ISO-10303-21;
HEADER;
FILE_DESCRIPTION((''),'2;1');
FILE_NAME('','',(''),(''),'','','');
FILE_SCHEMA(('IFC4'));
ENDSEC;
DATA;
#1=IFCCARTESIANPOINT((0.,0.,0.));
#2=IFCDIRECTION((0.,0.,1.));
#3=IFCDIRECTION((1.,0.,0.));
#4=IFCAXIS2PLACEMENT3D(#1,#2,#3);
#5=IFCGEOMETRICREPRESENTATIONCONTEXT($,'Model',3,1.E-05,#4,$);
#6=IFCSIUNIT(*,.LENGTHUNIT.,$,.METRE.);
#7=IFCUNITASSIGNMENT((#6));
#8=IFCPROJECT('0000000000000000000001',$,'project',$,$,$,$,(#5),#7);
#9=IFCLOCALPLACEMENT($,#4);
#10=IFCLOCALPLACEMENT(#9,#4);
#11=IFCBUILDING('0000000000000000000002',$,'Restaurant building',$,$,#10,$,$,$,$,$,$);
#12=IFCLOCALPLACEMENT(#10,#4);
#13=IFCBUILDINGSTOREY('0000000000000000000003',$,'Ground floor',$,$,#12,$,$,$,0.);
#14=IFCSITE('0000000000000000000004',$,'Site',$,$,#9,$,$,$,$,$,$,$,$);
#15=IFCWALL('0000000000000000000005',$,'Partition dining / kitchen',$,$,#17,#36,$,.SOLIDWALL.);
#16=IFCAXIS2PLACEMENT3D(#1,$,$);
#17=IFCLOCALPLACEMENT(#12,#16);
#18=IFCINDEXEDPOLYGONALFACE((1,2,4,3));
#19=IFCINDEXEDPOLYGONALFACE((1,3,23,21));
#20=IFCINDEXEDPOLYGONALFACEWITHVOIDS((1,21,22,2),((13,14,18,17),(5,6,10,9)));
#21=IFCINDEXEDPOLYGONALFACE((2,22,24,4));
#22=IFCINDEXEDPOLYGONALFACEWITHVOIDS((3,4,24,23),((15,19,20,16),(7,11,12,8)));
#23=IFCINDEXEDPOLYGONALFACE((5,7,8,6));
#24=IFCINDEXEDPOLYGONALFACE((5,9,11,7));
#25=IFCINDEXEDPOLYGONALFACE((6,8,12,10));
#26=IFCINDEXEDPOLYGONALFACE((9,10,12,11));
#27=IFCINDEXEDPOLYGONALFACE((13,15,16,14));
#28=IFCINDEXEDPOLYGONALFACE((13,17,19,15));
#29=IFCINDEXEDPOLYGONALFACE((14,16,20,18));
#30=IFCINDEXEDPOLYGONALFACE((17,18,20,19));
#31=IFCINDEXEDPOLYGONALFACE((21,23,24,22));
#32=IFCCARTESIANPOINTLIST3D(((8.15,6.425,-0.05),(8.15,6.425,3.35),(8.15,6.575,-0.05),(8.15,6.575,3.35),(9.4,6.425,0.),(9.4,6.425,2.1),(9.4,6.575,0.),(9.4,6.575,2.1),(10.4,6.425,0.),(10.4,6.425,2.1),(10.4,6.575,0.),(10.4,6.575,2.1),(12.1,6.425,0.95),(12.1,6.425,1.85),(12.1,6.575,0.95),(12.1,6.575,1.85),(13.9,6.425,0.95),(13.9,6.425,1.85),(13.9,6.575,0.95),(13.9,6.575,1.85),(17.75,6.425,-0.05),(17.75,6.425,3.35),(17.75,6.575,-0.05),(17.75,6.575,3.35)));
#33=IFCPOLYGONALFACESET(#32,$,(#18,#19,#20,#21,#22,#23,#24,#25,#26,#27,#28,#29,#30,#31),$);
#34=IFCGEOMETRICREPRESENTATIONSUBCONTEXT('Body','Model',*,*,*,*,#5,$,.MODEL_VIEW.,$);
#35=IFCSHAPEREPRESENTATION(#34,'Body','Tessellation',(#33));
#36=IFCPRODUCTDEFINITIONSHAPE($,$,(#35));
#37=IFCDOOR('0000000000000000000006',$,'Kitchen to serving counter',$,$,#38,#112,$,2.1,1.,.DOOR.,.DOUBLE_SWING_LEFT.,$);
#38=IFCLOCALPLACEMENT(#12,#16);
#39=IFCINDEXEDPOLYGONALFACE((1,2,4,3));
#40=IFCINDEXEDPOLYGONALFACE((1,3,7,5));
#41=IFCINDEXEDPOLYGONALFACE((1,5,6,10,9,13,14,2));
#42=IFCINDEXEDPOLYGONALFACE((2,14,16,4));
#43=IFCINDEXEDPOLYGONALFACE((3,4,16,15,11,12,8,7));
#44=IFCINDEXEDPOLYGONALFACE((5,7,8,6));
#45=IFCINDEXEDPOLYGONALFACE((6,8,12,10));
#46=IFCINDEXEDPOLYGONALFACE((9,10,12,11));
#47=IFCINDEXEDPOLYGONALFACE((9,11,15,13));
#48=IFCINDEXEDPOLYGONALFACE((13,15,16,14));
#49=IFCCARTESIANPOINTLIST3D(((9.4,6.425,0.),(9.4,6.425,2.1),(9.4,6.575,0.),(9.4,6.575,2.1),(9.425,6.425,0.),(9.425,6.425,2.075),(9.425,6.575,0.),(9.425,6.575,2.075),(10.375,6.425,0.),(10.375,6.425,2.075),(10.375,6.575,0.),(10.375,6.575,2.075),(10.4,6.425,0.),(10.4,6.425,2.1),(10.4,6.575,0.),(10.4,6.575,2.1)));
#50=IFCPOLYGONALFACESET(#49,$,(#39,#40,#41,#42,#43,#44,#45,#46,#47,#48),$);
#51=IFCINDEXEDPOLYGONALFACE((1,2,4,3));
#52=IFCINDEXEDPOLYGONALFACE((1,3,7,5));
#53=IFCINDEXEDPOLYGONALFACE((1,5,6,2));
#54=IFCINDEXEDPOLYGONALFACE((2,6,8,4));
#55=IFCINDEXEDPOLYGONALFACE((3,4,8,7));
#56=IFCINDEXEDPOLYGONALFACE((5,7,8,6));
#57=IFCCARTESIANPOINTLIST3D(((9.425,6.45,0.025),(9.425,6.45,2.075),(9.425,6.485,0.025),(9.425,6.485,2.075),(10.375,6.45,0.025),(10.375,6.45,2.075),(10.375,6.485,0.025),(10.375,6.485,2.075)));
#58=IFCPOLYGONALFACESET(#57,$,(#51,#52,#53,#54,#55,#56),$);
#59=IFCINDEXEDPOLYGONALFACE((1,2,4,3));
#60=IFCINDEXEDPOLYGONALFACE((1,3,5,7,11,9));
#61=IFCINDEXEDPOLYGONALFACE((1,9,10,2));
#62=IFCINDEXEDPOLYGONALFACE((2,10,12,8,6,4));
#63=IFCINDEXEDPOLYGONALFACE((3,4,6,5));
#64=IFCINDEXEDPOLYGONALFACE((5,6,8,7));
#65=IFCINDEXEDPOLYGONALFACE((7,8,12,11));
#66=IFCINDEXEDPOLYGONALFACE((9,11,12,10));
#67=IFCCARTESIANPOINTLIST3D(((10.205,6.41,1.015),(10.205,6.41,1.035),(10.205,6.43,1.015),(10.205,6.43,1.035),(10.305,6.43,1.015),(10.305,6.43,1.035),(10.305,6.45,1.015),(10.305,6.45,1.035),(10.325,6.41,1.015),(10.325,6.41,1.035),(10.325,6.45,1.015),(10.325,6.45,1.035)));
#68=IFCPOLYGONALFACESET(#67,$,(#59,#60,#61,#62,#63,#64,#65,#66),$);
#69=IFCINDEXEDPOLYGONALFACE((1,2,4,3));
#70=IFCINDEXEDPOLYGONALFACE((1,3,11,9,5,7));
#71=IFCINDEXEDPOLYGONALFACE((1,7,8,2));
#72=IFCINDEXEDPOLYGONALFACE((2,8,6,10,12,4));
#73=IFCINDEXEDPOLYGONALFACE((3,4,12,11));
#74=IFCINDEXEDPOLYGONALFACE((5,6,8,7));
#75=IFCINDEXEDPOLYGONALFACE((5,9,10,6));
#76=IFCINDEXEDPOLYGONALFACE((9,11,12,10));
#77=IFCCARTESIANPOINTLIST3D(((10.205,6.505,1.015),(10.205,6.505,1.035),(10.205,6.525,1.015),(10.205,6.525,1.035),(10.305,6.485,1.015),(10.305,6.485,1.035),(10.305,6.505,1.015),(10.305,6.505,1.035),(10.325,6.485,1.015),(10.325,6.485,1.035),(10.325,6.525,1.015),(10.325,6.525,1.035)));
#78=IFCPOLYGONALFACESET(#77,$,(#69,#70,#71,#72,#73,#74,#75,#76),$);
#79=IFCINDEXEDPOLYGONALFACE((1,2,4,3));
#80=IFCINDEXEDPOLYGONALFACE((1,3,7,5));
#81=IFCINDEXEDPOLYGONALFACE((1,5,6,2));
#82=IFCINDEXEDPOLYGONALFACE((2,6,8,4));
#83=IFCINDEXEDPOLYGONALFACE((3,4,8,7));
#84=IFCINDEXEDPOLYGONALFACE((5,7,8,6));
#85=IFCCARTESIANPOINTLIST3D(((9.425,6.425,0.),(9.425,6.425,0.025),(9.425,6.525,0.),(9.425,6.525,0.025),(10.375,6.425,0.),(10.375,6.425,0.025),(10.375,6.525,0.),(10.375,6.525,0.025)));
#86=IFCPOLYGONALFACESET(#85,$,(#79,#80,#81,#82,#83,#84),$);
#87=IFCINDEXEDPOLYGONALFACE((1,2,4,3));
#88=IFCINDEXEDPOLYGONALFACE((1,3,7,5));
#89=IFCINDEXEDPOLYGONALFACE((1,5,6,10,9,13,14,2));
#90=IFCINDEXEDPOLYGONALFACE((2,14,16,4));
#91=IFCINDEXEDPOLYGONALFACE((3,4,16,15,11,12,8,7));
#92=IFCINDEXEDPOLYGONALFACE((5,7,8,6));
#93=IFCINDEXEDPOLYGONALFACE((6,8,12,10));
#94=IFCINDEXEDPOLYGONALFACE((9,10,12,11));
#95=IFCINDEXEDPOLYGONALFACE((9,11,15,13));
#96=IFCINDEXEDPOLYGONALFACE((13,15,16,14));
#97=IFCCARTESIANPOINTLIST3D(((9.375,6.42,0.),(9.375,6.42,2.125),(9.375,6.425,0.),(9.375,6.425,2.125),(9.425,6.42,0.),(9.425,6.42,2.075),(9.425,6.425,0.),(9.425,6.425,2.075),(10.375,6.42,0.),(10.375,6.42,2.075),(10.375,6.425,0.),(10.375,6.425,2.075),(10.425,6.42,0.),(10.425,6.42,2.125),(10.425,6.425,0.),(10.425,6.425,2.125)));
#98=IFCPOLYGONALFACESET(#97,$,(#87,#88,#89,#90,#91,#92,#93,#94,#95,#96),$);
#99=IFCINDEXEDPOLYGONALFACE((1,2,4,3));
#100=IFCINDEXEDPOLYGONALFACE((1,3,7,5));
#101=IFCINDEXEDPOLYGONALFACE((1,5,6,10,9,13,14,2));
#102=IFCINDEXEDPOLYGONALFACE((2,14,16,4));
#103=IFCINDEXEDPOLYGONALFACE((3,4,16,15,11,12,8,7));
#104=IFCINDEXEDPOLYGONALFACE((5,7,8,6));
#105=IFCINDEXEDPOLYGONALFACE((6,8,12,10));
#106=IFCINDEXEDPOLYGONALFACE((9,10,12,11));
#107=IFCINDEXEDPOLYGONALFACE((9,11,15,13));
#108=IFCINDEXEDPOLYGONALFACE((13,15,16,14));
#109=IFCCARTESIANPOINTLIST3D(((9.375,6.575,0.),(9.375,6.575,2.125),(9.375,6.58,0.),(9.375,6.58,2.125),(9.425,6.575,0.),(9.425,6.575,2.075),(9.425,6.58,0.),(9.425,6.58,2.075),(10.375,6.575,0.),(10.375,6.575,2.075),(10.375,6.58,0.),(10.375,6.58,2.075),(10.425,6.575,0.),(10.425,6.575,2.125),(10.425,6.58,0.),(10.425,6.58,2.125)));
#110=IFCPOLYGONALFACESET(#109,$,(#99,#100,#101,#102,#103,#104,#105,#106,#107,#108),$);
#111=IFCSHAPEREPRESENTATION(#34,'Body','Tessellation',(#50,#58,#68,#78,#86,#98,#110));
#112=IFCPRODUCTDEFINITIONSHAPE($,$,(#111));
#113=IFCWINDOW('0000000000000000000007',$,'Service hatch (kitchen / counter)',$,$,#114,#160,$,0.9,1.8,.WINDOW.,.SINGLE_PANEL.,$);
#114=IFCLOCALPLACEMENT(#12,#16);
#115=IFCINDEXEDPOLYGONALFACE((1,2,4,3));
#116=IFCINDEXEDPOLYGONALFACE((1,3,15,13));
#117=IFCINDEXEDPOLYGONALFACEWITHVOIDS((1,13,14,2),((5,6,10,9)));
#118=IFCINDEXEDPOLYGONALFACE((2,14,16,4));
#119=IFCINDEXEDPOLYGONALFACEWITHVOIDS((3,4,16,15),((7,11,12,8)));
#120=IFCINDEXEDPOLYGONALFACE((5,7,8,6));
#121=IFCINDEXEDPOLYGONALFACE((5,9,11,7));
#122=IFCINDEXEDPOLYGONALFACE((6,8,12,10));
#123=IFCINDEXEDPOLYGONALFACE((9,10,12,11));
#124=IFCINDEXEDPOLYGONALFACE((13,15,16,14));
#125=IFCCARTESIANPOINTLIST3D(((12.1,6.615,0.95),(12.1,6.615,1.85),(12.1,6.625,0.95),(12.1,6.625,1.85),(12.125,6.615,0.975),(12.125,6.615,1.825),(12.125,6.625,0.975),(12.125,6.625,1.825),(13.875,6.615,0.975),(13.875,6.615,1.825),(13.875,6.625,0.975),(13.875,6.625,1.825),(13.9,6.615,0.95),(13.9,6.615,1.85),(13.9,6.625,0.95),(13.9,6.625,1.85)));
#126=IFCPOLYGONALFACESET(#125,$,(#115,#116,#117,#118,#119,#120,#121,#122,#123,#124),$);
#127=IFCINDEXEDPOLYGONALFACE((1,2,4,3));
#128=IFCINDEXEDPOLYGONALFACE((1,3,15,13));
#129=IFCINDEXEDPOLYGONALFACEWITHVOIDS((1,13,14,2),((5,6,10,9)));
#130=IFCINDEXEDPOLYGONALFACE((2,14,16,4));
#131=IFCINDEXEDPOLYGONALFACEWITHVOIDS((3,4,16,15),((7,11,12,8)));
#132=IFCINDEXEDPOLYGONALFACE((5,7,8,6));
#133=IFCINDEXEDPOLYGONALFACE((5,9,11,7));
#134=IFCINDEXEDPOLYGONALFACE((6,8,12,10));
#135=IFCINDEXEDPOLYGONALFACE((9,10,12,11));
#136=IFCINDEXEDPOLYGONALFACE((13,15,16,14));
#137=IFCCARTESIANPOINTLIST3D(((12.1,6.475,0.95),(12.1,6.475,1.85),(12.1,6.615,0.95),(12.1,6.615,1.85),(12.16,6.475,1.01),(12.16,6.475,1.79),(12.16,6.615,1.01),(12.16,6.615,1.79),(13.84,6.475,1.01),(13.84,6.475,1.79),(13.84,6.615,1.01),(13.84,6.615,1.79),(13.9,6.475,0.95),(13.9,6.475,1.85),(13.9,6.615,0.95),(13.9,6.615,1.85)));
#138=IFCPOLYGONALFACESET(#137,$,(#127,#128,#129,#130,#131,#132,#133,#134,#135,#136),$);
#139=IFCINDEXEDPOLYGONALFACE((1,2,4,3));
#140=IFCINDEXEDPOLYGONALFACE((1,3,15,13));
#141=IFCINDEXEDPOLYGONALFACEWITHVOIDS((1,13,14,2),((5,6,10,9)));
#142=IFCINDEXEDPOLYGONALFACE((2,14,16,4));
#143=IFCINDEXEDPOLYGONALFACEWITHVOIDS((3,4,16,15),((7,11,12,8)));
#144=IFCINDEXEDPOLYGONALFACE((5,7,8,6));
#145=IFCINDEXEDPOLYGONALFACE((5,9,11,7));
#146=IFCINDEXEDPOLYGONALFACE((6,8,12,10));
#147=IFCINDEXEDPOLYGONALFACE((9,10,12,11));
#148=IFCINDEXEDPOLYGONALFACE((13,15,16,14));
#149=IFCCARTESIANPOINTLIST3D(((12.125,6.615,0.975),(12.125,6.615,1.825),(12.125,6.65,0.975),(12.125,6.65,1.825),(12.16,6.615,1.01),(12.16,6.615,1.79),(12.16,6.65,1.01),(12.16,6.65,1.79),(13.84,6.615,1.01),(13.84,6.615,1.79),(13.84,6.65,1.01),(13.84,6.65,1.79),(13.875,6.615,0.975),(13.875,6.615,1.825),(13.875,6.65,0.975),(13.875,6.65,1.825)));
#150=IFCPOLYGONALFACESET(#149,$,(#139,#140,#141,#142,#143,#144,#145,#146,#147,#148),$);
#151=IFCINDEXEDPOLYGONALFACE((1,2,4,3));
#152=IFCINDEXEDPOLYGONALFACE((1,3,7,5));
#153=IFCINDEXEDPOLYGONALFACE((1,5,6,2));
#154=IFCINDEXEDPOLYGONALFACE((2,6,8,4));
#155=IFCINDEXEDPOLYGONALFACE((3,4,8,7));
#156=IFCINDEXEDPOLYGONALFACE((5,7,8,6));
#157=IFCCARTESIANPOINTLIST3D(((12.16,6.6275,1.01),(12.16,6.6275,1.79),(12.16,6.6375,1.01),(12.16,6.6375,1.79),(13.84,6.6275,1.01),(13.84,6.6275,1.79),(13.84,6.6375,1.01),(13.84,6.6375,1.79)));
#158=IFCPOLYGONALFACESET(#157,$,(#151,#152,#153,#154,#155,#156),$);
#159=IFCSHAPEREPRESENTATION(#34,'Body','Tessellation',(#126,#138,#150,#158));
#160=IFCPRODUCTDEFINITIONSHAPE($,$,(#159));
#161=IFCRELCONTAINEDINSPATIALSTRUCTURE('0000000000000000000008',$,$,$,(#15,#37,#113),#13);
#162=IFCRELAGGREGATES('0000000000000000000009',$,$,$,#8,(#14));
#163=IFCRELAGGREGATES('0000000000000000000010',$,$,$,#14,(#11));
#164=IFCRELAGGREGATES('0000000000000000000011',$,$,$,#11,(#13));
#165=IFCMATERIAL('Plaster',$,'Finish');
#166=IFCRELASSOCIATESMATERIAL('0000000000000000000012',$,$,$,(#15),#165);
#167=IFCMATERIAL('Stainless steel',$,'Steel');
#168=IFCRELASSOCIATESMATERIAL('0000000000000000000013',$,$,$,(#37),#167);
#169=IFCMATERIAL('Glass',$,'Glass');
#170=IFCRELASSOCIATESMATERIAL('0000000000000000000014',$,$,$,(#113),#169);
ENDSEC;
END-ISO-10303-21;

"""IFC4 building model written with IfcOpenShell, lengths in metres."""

from ifc_helpers import new_model, si_unit, frame, origin_with_axes, origin_2d, place, context, subcontext, project, spatial, line, indexed_curve, rectangle, outline, extrude, material, element, fill, save


model = new_model("IFC4")

# Units and contexts
model_context = context("Model", 3, precision=1e-05, world=origin_with_axes())
body_context = subcontext(model_context, "Body", "Model", "MODEL_VIEW")
ifc_project = project(units=[si_unit("LENGTHUNIT", "METRE")], contexts=[model_context])

# Site, building, storey
site_placement = place(None, origin_with_axes())
site = spatial("IfcSite", under=ifc_project, at=site_placement, Name="Site")
building_placement = place(site_placement, origin_with_axes())
building = spatial("IfcBuilding", under=site, at=building_placement, Name="Restaurant building")
storey_placement = place(building_placement, origin_with_axes())
storey = spatial("IfcBuildingStorey", under=building, at=storey_placement, Name="Ground floor", Elevation=0.0)

# Wall, openings, door, window
ifc_material_1 = material(Name="Plaster", Category="Finish")
wall_1_placement = place(storey_placement, frame((8.15, 6.5, 0.0)))
wall_1 = element("IfcWall", 1, at=wall_1_placement, inside=storey, material=ifc_material_1, Name="Partition dining / kitchen", PredefinedType="SOLIDWALL", context=body_context, shape_type="SweptSolid", body=[
    extrude(rectangle(XDim=9.6, YDim=0.15, at=origin_2d()), frame((4.8, 0.0, -0.05)), (0.0, 0.0, 1.0), 3.4),
])
opening_1_placement = place(wall_1_placement, frame((1.25, -0.075, 0.0), z_axis=(0.0, 0.0, 1.0), x_axis=(1.0, 0.0, 0.0)))
opening_1 = element("IfcOpeningElement", 2, at=opening_1_placement, cuts=wall_1, PredefinedType="OPENING", context=body_context, shape_type="SweptSolid", body=[
    extrude(rectangle(XDim=1.0, YDim=0.25, at=origin_2d()), frame((0.5, 0.075, 0.0)), (0.0, 0.0, 1.0), 2.1),
])
opening_2_placement = place(wall_1_placement, frame((3.95, -0.075, 0.95), z_axis=(0.0, 0.0, 1.0), x_axis=(1.0, 0.0, 0.0)))
opening_2 = element("IfcOpeningElement", 3, at=opening_2_placement, cuts=wall_1, PredefinedType="OPENING", context=body_context, shape_type="SweptSolid", body=[
    extrude(rectangle(XDim=1.8, YDim=0.25, at=origin_2d()), frame((0.9, 0.075, 0.0)), (0.0, 0.0, 1.0), 0.9),
])
ifc_material_2 = material(Name="Stainless steel", Category="Steel")
door_1_placement = place(storey_placement, frame((9.4, 6.425, 0.0)))
door_1 = element("IfcDoor", 4, at=door_1_placement, inside=storey, material=ifc_material_2, Name="Kitchen to serving counter", OperationType="DOUBLE_SWING_LEFT", OverallHeight=2.1, OverallWidth=1.0, PredefinedType="DOOR", context=body_context, shape_type="SweptSolid", body=[
    extrude(outline(indexed_curve([(0.0, 0.0), (0.0, 2.1), (1.0, 2.1), (1.0, 0.0), (0.975, 0.0), (0.975, 2.075), (0.025, 2.075), (0.025, 0.0)], segments=[line(1, 2, 3, 4, 5, 6, 7, 8, 1)])), frame((0.0, 0.0, 0.0), z_axis=(0.0, -1.0, 0.0), x_axis=(1.0, 0.0, 0.0)), (0.0, 0.0, -1.0), 0.15),
    extrude(outline(indexed_curve([(0.0, 0.0), (0.95, 0.0), (0.95, 0.035), (0.0, 0.035)], segments=[line(1, 2, 3, 4, 1)])), frame((0.025, 0.025, 0.025), z_axis=(0.0, 0.0, 1.0), x_axis=(1.0, 0.0, 0.0)), (0.0, 0.0, 1.0), 2.05),
    extrude(outline(indexed_curve([(0.0, 0.0), (0.0, -0.04), (-0.12, -0.04), (-0.12, -0.02), (-0.02, -0.02), (-0.02, 0.0)], segments=[line(1, 2, 3, 4, 5, 6, 1)])), frame((0.925, 0.025, 1.015), z_axis=(0.0, 0.0, 1.0), x_axis=(1.0, 0.0, 0.0)), (0.0, 0.0, 1.0), 0.02),
    extrude(outline(indexed_curve([(0.0, 0.0), (0.0, 0.04), (-0.12, 0.04), (-0.12, 0.02), (-0.02, 0.02), (-0.02, 0.0)], segments=[line(1, 2, 3, 4, 5, 6, 1)])), frame((0.925, 0.06, 1.015), z_axis=(0.0, 0.0, 1.0), x_axis=(1.0, 0.0, 0.0)), (0.0, 0.0, 1.0), 0.02),
    extrude(outline(indexed_curve([(0.0, 0.0), (0.95, 0.0), (0.95, 0.1), (0.0, 0.1)], segments=[line(1, 2, 3, 4, 1)])), frame((0.025, 0.0, 0.0), z_axis=(0.0, 0.0, 1.0), x_axis=(1.0, 0.0, 0.0)), (0.0, 0.0, 1.0), 0.025),
    extrude(outline(indexed_curve([(0.0, 0.0), (0.0, 2.125), (1.05, 2.125), (1.05, 0.0), (1.0, 0.0), (1.0, 2.075), (0.05, 2.075), (0.05, 0.0)], segments=[line(1, 2, 3, 4, 5, 6, 7, 8, 1)])), frame((-0.025, -0.005, 0.0), z_axis=(0.0, -1.0, 0.0), x_axis=(1.0, 0.0, 0.0)), (0.0, 0.0, -1.0), 0.005),
    extrude(outline(indexed_curve([(0.0, 0.0), (0.0, 2.125), (1.05, 2.125), (1.05, 0.0), (1.0, 0.0), (1.0, 2.075), (0.05, 2.075), (0.05, 0.0)], segments=[line(1, 2, 3, 4, 5, 6, 7, 8, 1)])), frame((-0.025, 0.15, 0.0), z_axis=(0.0, -1.0, 0.0), x_axis=(1.0, 0.0, 0.0)), (0.0, 0.0, -1.0), 0.005),
])
fill(opening_1, door_1)
ifc_material_3 = material(Name="Glass", Category="Glass")
window_placement = place(storey_placement, frame((12.1, 6.425, 0.95)))
window = element("IfcWindow", 5, at=window_placement, inside=storey, material=ifc_material_3, Name="Service hatch (kitchen / counter)", OverallHeight=0.9, OverallWidth=1.8, PartitioningType="SINGLE_PANEL", PredefinedType="WINDOW", context=body_context, shape_type="SweptSolid", body=[
    extrude(outline(indexed_curve([(0.0, 0.0), (1.8, 0.0), (1.8, 0.9), (0.0, 0.9)], segments=[line(1, 2, 3, 4, 1)]), holes=[indexed_curve([(0.025, 0.025), (1.775, 0.025), (1.775, 0.875), (0.025, 0.875)], segments=[line(1, 2, 3, 4, 1)])]), frame((0.0, 0.19, 0.0), z_axis=(0.0, -1.0, 0.0), x_axis=(1.0, 0.0, 0.0)), (0.0, 0.0, -1.0), 0.01),
    extrude(outline(indexed_curve([(0.0, 0.0), (1.8, 0.0), (1.8, 0.9), (0.0, 0.9)], segments=[line(1, 2, 3, 4, 1)]), holes=[indexed_curve([(0.06, 0.06), (1.74, 0.06), (1.74, 0.84), (0.06, 0.84)], segments=[line(1, 2, 3, 4, 1)])]), frame((0.0, 0.05, 0.0), z_axis=(0.0, -1.0, 0.0), x_axis=(1.0, 0.0, 0.0)), (0.0, 0.0, -1.0), 0.14),
    extrude(outline(indexed_curve([(0.0, 0.0), (1.75, 0.0), (1.75, 0.85), (0.0, 0.85)], segments=[line(1, 2, 3, 4, 1)]), holes=[indexed_curve([(0.035, 0.035), (1.715, 0.035), (1.715, 0.815), (0.035, 0.815)], segments=[line(1, 2, 3, 4, 1)])]), frame((0.025, 0.19, 0.025), z_axis=(0.0, -1.0, 0.0), x_axis=(1.0, 0.0, 0.0)), (0.0, 0.0, -1.0), 0.035),
    extrude(outline(indexed_curve([(0.035, 0.035), (1.715, 0.035), (1.715, 0.815), (0.035, 0.815)], segments=[line(1, 2, 3, 4, 1)])), frame((0.025, 0.2025, 0.025), z_axis=(0.0, -1.0, 0.0), x_axis=(1.0, 0.0, 0.0)), (0.0, 0.0, -1.0), 0.01),
])
fill(opening_2, window)

save(model, "model.ifc")
